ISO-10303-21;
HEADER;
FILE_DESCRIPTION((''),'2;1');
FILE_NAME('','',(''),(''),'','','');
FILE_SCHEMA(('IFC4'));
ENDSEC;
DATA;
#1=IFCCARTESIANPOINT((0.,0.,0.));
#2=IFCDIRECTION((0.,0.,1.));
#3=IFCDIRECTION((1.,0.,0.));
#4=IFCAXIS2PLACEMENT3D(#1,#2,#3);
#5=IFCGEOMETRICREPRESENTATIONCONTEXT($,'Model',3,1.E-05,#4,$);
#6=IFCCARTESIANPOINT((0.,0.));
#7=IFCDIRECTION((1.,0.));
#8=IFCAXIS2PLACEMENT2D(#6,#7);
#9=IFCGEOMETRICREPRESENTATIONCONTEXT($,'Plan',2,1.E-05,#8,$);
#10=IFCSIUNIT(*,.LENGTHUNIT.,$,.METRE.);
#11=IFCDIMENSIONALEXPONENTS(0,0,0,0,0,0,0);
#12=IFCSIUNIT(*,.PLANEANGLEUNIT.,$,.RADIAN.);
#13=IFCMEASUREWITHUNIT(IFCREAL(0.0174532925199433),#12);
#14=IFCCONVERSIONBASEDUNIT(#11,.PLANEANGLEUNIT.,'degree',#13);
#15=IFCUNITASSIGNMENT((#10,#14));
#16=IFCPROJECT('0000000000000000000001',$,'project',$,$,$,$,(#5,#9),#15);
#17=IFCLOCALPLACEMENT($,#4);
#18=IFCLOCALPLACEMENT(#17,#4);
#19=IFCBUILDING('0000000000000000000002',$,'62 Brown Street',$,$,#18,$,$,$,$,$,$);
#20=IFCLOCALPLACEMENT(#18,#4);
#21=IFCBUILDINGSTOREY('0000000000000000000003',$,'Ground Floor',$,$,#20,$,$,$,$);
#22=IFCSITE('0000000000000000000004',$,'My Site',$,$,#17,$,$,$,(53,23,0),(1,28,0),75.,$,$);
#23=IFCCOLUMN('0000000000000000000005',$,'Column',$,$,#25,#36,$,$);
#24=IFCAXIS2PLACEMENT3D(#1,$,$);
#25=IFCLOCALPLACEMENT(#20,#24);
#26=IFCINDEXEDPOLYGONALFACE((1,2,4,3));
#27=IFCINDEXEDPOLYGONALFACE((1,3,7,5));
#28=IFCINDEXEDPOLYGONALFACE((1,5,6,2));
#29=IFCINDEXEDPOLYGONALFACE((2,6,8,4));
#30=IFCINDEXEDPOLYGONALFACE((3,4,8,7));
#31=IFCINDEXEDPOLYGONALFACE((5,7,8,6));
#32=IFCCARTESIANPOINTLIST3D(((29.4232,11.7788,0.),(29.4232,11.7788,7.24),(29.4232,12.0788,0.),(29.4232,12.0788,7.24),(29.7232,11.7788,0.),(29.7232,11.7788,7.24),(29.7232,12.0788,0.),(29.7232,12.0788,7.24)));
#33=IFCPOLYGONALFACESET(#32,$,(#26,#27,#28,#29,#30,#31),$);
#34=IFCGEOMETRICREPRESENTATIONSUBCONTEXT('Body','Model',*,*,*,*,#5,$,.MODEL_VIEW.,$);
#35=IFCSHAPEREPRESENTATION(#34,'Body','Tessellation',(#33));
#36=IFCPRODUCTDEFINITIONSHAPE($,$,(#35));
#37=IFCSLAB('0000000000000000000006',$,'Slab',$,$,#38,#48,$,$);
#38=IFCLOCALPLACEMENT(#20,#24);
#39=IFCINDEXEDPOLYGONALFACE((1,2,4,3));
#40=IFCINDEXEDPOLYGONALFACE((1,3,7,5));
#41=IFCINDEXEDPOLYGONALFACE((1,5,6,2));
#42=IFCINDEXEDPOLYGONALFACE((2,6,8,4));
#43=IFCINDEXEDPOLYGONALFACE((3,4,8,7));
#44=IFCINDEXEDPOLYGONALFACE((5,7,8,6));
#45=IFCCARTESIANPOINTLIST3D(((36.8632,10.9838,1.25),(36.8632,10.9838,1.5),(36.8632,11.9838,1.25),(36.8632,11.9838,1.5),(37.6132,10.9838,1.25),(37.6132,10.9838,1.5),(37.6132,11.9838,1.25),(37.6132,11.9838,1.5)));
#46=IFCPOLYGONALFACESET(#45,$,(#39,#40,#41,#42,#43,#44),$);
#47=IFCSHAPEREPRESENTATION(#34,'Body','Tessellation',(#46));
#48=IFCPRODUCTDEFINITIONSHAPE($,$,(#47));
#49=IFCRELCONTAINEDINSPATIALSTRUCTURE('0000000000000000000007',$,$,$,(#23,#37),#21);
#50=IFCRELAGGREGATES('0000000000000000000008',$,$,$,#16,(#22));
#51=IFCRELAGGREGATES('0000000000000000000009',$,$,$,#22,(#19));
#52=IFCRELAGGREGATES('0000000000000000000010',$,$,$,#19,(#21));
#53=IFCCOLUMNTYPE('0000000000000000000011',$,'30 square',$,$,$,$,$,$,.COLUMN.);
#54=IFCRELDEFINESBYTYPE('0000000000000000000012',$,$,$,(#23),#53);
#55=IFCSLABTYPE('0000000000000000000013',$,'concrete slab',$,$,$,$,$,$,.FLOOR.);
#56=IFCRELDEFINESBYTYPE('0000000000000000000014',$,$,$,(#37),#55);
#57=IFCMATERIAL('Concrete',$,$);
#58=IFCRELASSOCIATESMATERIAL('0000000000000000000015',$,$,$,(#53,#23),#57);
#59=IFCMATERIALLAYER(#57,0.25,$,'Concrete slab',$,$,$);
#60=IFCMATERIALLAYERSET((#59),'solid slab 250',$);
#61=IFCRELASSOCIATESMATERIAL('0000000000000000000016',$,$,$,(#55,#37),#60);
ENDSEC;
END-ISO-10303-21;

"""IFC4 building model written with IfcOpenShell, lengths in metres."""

from ifc_helpers import new_model, entity, si_unit, converted_unit, frame, origin_with_axes, origin_2d_with_axis, place, context, subcontext, project, spatial, line, indexed_curve, rectangle, outline, extrude, material, layer, layer_set, layer_usage, material_profile, profile_set, profile_usage, type_object, element, save


model = new_model("IFC4")

# Units and contexts
model_context = context("Model", 3, precision=1e-05, world=origin_with_axes())
plan_context = context("Plan", 2, precision=1e-05, world=origin_2d_with_axis())
body_context_1 = subcontext(model_context, "Body", "Model", "MODEL_VIEW")
ifc_project = project(units=[si_unit("LENGTHUNIT", "METRE"), converted_unit("PLANEANGLEUNIT", "degree", entity("IfcReal", 0.0174532925199433), si_unit("PLANEANGLEUNIT", "RADIAN"), dimensions=[0, 0, 0, 0, 0, 0, 0])], contexts=[model_context, plan_context])

# Site, building, storey
site_placement = place(None, origin_with_axes())
site = spatial("IfcSite", under=ifc_project, at=site_placement, Name="My Site", RefLatitude=(53, 23, 0), RefLongitude=(1, 28, 0), RefElevation=75.0)
building_placement = place(site_placement, origin_with_axes())
building = spatial("IfcBuilding", under=site, at=building_placement, Name="62 Brown Street")
storey_placement = place(building_placement, origin_with_axes())
storey = spatial("IfcBuildingStorey", under=building, at=storey_placement, Name="Ground Floor")

# Column
ifc_material_1 = material(Name="Concrete")
ifc_material_profile_1 = material_profile(ifc_material_1, rectangle(XDim=0.3, YDim=0.3))
ifc_profile_set_1 = profile_set([ifc_material_profile_1])
ifc_profile_usage_1 = profile_usage(ifc_profile_set_1, cardinal=5)
column_type = type_object("IfcColumnType", Name="30 square", PredefinedType="COLUMN", material=ifc_profile_set_1)
column_placement = place(storey_placement, frame((29.5732, 11.9288, 0.0), z_axis=(0.0, 0.0, 1.0), x_axis=(1.0, 0.0, 0.0)))
element("IfcColumn", 1, at=column_placement, inside=storey, type_object=column_type, material=ifc_profile_usage_1, Name="Column", context=body_context_1, shape_type="SweptSolid", body=[
    extrude(rectangle(XDim=0.3, YDim=0.3), origin_with_axes(), (0.0, 0.0, 1.0), 7.24),
])

# Slab
ifc_layer_1 = layer(ifc_material_1, 0.25, Name="Concrete slab")
ifc_layer_set_1 = layer_set([ifc_layer_1], Name="solid slab 250")
slab_type = type_object("IfcSlabType", Name="concrete slab", PredefinedType="FLOOR", material=ifc_layer_set_1)
ifc_layer_usage_1 = layer_usage(ifc_layer_set_1, "AXIS3", "POSITIVE", 0.0)
slab_1_placement = place(storey_placement, frame((36.8632, 10.9838, 1.25), z_axis=(0.0, 0.0, 1.0), x_axis=(1.0, 0.0, 0.0)))
element("IfcSlab", 2, at=slab_1_placement, inside=storey, type_object=slab_type, material=ifc_layer_usage_1, Name="Slab", context=body_context_1, shape_type="SweptSolid", body=[
    extrude(outline(indexed_curve([(0.0, 0.0), (0.75, 0.0), (0.75, 1.0), (0.0, 1.0)], segments=[line(4, 1), line(1, 2), line(2, 3), line(3, 4)], self_intersect=False)), None, (0.0, 0.0, 1.0), 0.25),
])

save(model, "model.ifc")
